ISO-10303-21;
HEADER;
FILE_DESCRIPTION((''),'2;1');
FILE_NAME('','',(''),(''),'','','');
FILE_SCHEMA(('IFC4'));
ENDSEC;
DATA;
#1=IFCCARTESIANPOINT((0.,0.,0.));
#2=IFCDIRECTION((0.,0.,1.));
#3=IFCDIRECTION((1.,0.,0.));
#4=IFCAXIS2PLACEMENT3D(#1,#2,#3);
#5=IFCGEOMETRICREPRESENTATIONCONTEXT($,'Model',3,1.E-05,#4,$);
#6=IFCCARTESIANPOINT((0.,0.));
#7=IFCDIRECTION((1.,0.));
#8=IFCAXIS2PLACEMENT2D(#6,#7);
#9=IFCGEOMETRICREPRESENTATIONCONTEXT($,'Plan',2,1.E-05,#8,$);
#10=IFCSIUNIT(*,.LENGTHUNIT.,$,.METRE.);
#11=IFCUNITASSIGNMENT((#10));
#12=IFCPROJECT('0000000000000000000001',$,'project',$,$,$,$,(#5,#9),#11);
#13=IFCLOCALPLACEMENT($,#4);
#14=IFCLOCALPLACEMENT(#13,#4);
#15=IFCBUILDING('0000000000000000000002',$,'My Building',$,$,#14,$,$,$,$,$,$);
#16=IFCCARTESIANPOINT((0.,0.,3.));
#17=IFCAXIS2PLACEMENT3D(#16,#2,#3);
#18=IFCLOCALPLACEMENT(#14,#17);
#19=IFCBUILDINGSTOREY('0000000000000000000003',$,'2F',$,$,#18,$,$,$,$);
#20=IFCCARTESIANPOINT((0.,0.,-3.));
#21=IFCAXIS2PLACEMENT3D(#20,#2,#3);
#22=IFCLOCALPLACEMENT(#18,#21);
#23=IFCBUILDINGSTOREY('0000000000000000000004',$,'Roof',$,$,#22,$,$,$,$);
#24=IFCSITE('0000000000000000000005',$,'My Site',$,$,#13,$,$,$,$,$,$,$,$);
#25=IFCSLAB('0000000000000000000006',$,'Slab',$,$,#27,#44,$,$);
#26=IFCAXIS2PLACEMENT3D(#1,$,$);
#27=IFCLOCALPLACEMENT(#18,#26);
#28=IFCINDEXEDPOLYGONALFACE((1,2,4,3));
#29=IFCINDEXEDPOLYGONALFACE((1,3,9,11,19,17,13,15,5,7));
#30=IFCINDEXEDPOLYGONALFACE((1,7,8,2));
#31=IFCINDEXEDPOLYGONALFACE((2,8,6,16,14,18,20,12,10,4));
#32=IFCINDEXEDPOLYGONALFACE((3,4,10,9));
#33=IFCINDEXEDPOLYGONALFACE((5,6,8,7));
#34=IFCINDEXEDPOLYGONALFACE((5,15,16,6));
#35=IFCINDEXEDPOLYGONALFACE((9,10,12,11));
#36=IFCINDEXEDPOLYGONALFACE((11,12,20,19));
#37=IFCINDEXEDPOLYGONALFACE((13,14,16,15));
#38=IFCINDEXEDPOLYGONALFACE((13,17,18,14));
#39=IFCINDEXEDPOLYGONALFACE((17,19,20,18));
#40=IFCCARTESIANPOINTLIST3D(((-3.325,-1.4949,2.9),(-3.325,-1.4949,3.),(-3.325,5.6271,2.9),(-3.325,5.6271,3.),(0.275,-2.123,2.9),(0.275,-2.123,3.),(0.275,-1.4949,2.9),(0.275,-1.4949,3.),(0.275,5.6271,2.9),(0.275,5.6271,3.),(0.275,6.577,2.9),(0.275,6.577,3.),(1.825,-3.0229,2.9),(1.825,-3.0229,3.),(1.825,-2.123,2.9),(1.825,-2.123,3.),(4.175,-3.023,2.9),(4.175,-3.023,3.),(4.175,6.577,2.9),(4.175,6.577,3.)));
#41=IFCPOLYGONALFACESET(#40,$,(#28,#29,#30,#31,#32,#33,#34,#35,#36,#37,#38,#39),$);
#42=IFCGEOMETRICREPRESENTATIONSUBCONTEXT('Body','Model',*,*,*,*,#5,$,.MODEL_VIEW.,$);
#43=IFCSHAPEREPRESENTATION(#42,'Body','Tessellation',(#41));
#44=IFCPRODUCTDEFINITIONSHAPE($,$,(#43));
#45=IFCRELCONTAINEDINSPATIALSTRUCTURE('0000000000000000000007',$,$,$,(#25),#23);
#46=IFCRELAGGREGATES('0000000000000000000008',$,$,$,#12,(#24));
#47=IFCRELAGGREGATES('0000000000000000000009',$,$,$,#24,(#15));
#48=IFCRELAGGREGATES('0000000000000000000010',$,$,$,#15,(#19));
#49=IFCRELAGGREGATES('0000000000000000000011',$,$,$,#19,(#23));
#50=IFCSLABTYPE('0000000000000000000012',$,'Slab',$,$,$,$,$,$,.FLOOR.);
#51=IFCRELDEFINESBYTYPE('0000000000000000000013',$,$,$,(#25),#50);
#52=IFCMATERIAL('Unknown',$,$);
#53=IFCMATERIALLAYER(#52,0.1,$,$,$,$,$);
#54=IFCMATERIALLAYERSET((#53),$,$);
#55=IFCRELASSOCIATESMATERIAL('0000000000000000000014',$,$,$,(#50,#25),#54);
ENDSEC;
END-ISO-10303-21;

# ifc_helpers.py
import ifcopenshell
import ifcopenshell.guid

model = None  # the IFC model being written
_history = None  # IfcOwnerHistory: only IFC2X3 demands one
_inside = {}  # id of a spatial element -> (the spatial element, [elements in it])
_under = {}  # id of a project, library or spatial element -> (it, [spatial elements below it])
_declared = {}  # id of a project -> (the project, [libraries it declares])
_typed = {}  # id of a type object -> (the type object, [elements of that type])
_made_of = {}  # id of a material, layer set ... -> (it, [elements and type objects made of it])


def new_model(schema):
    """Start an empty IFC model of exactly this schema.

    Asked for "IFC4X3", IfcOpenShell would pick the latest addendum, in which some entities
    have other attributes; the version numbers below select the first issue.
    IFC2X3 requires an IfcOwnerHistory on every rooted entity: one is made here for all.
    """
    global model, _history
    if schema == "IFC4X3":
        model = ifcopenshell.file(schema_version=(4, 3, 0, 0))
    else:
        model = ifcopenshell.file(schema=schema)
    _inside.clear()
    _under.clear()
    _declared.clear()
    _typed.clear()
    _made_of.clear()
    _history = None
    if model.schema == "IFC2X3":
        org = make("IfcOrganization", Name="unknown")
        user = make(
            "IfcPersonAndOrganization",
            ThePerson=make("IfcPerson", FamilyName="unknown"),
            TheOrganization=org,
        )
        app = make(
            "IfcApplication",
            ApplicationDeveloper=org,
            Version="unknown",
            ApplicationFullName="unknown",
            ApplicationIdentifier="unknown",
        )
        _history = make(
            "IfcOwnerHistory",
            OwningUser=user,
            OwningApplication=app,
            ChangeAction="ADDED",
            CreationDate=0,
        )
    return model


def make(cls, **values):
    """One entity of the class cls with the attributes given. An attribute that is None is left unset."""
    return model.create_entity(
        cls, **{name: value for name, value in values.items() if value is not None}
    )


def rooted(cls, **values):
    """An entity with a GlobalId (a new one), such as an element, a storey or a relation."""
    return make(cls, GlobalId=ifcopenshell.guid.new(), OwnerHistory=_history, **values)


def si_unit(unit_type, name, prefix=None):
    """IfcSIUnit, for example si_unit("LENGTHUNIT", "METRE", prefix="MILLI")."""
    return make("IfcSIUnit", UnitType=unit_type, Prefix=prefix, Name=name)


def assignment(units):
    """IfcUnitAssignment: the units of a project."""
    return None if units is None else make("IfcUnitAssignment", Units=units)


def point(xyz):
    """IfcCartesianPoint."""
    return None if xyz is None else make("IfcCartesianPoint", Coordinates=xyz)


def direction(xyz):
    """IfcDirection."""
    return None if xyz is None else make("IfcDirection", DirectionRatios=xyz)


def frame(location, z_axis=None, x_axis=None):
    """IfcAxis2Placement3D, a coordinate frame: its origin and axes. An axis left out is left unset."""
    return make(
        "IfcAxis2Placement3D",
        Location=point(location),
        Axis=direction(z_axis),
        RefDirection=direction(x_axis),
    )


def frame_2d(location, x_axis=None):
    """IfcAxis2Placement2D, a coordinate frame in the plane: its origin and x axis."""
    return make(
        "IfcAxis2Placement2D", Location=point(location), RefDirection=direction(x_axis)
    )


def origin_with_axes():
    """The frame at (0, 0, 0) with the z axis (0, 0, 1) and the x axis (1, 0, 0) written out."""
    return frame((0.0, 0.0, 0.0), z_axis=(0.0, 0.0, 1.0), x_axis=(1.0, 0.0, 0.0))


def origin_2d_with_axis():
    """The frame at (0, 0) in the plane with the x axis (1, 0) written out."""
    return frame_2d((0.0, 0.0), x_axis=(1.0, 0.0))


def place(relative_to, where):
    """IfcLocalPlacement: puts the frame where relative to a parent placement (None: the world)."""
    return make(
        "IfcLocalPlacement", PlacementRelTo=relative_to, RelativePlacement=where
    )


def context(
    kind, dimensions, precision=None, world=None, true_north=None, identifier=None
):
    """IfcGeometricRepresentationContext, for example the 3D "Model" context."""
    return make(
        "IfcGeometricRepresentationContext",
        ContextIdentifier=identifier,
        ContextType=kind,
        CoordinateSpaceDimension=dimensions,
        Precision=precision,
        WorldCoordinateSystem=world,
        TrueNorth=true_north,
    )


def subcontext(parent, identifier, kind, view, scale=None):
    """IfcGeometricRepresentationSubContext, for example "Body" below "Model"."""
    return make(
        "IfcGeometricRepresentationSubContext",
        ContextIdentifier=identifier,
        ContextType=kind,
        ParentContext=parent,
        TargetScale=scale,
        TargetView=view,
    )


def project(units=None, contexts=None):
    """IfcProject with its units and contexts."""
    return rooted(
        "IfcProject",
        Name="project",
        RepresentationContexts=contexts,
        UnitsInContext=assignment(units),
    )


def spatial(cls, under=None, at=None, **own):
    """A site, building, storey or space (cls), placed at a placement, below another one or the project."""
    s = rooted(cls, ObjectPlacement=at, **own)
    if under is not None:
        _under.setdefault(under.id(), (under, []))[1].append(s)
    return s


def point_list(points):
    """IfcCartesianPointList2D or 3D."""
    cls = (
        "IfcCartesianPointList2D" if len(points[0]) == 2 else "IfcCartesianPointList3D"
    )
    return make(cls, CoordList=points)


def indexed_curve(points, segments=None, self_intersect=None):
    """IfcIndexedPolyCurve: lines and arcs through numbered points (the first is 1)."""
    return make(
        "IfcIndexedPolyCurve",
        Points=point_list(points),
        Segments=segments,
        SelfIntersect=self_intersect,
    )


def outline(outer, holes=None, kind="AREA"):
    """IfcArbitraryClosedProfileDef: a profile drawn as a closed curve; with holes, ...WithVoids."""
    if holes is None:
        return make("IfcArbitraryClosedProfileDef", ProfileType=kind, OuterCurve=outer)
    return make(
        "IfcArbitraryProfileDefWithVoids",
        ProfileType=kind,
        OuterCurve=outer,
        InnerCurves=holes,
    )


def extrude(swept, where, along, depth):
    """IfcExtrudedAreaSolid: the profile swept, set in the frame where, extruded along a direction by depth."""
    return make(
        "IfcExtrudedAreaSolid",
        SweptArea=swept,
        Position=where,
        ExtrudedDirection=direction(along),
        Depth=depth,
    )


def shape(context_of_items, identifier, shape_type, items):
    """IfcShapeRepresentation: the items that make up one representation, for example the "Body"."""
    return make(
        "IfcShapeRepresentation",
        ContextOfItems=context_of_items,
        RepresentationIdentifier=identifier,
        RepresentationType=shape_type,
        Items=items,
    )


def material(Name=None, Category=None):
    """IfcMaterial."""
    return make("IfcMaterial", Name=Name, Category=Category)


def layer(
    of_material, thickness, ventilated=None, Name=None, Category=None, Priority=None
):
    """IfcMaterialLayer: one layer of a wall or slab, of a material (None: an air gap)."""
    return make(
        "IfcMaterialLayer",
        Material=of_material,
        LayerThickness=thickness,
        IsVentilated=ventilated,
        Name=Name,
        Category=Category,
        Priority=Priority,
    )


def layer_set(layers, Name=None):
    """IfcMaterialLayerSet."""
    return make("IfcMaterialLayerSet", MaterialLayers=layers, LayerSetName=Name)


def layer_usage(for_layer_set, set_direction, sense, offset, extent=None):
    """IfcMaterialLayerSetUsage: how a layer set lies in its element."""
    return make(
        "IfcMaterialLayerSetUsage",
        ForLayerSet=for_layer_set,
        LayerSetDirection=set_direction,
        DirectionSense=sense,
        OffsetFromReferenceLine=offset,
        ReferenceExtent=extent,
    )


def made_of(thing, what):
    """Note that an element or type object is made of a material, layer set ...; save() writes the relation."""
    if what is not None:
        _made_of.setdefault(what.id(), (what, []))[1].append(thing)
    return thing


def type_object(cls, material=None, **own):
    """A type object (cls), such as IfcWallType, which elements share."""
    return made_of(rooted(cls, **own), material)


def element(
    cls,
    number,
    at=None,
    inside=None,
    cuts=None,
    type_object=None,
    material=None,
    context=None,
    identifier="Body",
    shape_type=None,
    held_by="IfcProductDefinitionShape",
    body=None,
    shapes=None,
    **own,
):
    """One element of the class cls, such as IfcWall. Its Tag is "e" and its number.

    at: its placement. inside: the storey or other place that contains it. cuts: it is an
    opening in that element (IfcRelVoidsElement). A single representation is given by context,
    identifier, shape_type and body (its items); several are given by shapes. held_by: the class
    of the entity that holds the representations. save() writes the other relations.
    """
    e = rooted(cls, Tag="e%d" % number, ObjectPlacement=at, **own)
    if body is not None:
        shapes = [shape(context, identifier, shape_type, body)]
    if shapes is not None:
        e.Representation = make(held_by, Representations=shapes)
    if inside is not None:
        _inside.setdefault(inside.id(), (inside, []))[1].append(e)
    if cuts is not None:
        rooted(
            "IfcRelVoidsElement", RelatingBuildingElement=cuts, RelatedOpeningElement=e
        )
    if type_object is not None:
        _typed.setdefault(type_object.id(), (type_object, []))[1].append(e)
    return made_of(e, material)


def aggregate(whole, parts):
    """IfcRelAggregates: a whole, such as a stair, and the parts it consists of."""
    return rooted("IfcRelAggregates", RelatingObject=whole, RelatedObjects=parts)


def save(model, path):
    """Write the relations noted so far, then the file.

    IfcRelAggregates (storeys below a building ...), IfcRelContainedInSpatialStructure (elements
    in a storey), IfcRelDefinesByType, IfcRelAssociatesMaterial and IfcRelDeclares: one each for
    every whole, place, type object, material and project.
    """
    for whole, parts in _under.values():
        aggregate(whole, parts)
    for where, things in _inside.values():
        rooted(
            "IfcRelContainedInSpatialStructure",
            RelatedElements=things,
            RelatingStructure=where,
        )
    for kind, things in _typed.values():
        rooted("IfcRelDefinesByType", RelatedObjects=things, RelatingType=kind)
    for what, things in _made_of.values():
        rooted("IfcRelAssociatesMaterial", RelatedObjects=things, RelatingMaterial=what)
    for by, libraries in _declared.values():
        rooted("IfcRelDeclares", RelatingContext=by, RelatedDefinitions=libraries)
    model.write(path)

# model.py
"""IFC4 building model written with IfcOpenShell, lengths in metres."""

from ifc_helpers import new_model, si_unit, frame, origin_with_axes, origin_2d_with_axis, place, context, subcontext, project, spatial, indexed_curve, outline, extrude, material, layer, layer_set, layer_usage, type_object, element, save


model = new_model("IFC4")

# Units and contexts
model_context = context("Model", 3, precision=1e-05, world=origin_with_axes())
plan_context = context("Plan", 2, precision=1e-05, world=origin_2d_with_axis())
body_context = subcontext(model_context, "Body", "Model", "MODEL_VIEW")
ifc_project = project(units=[si_unit("LENGTHUNIT", "METRE")], contexts=[model_context, plan_context])

# Site, building, storeys
site_placement = place(None, origin_with_axes())
site = spatial("IfcSite", under=ifc_project, at=site_placement, Name="My Site")
building_placement = place(site_placement, origin_with_axes())
building = spatial("IfcBuilding", under=site, at=building_placement, Name="My Building")
storey_1_placement = place(building_placement, frame((0.0, 0.0, 3.0), z_axis=(0.0, 0.0, 1.0), x_axis=(1.0, 0.0, 0.0)))
storey_1 = spatial("IfcBuildingStorey", under=building, at=storey_1_placement, Name="2F")
storey_2_placement = place(storey_1_placement, frame((0.0, 0.0, -3.0), z_axis=(0.0, 0.0, 1.0), x_axis=(1.0, 0.0, 0.0)))
storey_2 = spatial("IfcBuildingStorey", under=storey_1, at=storey_2_placement, Name="Roof")

# Slab
ifc_material = material(Name="Unknown")
ifc_layer = layer(ifc_material, 0.1)
ifc_layer_set = layer_set([ifc_layer])
ifc_layer_usage = layer_usage(ifc_layer_set, "AXIS3", "POSITIVE", -0.1)
slab_type = type_object("IfcSlabType", Name="Slab", PredefinedType="FLOOR", material=ifc_layer_set)
slab_placement = place(storey_2_placement, frame((4.175, -3.023, 6.0), z_axis=(0.0, 0.0, 1.0), x_axis=(1.0, 0.0, 0.0)))
element("IfcSlab", 1, at=slab_placement, inside=storey_2, type_object=slab_type, material=ifc_layer_usage, Name="Slab", context=body_context, shape_type="SweptSolid", body=[
    extrude(outline(indexed_curve([(0.0, 0.0), (0.0, 9.6), (-3.9, 9.6), (-3.9, 8.65), (-7.5, 8.65), (-7.5, 1.5281), (-3.9, 1.5281), (-3.9, 0.9), (-2.35, 0.9), (-2.35, 0.0001), (0.0, 0.0)])), frame((0.0, 0.0, -0.1), z_axis=(0.0, 0.0, 1.0), x_axis=(1.0, 0.0, 0.0)), (0.0, 0.0, 1.0), 0.1),
])

save(model, "model.ifc")
